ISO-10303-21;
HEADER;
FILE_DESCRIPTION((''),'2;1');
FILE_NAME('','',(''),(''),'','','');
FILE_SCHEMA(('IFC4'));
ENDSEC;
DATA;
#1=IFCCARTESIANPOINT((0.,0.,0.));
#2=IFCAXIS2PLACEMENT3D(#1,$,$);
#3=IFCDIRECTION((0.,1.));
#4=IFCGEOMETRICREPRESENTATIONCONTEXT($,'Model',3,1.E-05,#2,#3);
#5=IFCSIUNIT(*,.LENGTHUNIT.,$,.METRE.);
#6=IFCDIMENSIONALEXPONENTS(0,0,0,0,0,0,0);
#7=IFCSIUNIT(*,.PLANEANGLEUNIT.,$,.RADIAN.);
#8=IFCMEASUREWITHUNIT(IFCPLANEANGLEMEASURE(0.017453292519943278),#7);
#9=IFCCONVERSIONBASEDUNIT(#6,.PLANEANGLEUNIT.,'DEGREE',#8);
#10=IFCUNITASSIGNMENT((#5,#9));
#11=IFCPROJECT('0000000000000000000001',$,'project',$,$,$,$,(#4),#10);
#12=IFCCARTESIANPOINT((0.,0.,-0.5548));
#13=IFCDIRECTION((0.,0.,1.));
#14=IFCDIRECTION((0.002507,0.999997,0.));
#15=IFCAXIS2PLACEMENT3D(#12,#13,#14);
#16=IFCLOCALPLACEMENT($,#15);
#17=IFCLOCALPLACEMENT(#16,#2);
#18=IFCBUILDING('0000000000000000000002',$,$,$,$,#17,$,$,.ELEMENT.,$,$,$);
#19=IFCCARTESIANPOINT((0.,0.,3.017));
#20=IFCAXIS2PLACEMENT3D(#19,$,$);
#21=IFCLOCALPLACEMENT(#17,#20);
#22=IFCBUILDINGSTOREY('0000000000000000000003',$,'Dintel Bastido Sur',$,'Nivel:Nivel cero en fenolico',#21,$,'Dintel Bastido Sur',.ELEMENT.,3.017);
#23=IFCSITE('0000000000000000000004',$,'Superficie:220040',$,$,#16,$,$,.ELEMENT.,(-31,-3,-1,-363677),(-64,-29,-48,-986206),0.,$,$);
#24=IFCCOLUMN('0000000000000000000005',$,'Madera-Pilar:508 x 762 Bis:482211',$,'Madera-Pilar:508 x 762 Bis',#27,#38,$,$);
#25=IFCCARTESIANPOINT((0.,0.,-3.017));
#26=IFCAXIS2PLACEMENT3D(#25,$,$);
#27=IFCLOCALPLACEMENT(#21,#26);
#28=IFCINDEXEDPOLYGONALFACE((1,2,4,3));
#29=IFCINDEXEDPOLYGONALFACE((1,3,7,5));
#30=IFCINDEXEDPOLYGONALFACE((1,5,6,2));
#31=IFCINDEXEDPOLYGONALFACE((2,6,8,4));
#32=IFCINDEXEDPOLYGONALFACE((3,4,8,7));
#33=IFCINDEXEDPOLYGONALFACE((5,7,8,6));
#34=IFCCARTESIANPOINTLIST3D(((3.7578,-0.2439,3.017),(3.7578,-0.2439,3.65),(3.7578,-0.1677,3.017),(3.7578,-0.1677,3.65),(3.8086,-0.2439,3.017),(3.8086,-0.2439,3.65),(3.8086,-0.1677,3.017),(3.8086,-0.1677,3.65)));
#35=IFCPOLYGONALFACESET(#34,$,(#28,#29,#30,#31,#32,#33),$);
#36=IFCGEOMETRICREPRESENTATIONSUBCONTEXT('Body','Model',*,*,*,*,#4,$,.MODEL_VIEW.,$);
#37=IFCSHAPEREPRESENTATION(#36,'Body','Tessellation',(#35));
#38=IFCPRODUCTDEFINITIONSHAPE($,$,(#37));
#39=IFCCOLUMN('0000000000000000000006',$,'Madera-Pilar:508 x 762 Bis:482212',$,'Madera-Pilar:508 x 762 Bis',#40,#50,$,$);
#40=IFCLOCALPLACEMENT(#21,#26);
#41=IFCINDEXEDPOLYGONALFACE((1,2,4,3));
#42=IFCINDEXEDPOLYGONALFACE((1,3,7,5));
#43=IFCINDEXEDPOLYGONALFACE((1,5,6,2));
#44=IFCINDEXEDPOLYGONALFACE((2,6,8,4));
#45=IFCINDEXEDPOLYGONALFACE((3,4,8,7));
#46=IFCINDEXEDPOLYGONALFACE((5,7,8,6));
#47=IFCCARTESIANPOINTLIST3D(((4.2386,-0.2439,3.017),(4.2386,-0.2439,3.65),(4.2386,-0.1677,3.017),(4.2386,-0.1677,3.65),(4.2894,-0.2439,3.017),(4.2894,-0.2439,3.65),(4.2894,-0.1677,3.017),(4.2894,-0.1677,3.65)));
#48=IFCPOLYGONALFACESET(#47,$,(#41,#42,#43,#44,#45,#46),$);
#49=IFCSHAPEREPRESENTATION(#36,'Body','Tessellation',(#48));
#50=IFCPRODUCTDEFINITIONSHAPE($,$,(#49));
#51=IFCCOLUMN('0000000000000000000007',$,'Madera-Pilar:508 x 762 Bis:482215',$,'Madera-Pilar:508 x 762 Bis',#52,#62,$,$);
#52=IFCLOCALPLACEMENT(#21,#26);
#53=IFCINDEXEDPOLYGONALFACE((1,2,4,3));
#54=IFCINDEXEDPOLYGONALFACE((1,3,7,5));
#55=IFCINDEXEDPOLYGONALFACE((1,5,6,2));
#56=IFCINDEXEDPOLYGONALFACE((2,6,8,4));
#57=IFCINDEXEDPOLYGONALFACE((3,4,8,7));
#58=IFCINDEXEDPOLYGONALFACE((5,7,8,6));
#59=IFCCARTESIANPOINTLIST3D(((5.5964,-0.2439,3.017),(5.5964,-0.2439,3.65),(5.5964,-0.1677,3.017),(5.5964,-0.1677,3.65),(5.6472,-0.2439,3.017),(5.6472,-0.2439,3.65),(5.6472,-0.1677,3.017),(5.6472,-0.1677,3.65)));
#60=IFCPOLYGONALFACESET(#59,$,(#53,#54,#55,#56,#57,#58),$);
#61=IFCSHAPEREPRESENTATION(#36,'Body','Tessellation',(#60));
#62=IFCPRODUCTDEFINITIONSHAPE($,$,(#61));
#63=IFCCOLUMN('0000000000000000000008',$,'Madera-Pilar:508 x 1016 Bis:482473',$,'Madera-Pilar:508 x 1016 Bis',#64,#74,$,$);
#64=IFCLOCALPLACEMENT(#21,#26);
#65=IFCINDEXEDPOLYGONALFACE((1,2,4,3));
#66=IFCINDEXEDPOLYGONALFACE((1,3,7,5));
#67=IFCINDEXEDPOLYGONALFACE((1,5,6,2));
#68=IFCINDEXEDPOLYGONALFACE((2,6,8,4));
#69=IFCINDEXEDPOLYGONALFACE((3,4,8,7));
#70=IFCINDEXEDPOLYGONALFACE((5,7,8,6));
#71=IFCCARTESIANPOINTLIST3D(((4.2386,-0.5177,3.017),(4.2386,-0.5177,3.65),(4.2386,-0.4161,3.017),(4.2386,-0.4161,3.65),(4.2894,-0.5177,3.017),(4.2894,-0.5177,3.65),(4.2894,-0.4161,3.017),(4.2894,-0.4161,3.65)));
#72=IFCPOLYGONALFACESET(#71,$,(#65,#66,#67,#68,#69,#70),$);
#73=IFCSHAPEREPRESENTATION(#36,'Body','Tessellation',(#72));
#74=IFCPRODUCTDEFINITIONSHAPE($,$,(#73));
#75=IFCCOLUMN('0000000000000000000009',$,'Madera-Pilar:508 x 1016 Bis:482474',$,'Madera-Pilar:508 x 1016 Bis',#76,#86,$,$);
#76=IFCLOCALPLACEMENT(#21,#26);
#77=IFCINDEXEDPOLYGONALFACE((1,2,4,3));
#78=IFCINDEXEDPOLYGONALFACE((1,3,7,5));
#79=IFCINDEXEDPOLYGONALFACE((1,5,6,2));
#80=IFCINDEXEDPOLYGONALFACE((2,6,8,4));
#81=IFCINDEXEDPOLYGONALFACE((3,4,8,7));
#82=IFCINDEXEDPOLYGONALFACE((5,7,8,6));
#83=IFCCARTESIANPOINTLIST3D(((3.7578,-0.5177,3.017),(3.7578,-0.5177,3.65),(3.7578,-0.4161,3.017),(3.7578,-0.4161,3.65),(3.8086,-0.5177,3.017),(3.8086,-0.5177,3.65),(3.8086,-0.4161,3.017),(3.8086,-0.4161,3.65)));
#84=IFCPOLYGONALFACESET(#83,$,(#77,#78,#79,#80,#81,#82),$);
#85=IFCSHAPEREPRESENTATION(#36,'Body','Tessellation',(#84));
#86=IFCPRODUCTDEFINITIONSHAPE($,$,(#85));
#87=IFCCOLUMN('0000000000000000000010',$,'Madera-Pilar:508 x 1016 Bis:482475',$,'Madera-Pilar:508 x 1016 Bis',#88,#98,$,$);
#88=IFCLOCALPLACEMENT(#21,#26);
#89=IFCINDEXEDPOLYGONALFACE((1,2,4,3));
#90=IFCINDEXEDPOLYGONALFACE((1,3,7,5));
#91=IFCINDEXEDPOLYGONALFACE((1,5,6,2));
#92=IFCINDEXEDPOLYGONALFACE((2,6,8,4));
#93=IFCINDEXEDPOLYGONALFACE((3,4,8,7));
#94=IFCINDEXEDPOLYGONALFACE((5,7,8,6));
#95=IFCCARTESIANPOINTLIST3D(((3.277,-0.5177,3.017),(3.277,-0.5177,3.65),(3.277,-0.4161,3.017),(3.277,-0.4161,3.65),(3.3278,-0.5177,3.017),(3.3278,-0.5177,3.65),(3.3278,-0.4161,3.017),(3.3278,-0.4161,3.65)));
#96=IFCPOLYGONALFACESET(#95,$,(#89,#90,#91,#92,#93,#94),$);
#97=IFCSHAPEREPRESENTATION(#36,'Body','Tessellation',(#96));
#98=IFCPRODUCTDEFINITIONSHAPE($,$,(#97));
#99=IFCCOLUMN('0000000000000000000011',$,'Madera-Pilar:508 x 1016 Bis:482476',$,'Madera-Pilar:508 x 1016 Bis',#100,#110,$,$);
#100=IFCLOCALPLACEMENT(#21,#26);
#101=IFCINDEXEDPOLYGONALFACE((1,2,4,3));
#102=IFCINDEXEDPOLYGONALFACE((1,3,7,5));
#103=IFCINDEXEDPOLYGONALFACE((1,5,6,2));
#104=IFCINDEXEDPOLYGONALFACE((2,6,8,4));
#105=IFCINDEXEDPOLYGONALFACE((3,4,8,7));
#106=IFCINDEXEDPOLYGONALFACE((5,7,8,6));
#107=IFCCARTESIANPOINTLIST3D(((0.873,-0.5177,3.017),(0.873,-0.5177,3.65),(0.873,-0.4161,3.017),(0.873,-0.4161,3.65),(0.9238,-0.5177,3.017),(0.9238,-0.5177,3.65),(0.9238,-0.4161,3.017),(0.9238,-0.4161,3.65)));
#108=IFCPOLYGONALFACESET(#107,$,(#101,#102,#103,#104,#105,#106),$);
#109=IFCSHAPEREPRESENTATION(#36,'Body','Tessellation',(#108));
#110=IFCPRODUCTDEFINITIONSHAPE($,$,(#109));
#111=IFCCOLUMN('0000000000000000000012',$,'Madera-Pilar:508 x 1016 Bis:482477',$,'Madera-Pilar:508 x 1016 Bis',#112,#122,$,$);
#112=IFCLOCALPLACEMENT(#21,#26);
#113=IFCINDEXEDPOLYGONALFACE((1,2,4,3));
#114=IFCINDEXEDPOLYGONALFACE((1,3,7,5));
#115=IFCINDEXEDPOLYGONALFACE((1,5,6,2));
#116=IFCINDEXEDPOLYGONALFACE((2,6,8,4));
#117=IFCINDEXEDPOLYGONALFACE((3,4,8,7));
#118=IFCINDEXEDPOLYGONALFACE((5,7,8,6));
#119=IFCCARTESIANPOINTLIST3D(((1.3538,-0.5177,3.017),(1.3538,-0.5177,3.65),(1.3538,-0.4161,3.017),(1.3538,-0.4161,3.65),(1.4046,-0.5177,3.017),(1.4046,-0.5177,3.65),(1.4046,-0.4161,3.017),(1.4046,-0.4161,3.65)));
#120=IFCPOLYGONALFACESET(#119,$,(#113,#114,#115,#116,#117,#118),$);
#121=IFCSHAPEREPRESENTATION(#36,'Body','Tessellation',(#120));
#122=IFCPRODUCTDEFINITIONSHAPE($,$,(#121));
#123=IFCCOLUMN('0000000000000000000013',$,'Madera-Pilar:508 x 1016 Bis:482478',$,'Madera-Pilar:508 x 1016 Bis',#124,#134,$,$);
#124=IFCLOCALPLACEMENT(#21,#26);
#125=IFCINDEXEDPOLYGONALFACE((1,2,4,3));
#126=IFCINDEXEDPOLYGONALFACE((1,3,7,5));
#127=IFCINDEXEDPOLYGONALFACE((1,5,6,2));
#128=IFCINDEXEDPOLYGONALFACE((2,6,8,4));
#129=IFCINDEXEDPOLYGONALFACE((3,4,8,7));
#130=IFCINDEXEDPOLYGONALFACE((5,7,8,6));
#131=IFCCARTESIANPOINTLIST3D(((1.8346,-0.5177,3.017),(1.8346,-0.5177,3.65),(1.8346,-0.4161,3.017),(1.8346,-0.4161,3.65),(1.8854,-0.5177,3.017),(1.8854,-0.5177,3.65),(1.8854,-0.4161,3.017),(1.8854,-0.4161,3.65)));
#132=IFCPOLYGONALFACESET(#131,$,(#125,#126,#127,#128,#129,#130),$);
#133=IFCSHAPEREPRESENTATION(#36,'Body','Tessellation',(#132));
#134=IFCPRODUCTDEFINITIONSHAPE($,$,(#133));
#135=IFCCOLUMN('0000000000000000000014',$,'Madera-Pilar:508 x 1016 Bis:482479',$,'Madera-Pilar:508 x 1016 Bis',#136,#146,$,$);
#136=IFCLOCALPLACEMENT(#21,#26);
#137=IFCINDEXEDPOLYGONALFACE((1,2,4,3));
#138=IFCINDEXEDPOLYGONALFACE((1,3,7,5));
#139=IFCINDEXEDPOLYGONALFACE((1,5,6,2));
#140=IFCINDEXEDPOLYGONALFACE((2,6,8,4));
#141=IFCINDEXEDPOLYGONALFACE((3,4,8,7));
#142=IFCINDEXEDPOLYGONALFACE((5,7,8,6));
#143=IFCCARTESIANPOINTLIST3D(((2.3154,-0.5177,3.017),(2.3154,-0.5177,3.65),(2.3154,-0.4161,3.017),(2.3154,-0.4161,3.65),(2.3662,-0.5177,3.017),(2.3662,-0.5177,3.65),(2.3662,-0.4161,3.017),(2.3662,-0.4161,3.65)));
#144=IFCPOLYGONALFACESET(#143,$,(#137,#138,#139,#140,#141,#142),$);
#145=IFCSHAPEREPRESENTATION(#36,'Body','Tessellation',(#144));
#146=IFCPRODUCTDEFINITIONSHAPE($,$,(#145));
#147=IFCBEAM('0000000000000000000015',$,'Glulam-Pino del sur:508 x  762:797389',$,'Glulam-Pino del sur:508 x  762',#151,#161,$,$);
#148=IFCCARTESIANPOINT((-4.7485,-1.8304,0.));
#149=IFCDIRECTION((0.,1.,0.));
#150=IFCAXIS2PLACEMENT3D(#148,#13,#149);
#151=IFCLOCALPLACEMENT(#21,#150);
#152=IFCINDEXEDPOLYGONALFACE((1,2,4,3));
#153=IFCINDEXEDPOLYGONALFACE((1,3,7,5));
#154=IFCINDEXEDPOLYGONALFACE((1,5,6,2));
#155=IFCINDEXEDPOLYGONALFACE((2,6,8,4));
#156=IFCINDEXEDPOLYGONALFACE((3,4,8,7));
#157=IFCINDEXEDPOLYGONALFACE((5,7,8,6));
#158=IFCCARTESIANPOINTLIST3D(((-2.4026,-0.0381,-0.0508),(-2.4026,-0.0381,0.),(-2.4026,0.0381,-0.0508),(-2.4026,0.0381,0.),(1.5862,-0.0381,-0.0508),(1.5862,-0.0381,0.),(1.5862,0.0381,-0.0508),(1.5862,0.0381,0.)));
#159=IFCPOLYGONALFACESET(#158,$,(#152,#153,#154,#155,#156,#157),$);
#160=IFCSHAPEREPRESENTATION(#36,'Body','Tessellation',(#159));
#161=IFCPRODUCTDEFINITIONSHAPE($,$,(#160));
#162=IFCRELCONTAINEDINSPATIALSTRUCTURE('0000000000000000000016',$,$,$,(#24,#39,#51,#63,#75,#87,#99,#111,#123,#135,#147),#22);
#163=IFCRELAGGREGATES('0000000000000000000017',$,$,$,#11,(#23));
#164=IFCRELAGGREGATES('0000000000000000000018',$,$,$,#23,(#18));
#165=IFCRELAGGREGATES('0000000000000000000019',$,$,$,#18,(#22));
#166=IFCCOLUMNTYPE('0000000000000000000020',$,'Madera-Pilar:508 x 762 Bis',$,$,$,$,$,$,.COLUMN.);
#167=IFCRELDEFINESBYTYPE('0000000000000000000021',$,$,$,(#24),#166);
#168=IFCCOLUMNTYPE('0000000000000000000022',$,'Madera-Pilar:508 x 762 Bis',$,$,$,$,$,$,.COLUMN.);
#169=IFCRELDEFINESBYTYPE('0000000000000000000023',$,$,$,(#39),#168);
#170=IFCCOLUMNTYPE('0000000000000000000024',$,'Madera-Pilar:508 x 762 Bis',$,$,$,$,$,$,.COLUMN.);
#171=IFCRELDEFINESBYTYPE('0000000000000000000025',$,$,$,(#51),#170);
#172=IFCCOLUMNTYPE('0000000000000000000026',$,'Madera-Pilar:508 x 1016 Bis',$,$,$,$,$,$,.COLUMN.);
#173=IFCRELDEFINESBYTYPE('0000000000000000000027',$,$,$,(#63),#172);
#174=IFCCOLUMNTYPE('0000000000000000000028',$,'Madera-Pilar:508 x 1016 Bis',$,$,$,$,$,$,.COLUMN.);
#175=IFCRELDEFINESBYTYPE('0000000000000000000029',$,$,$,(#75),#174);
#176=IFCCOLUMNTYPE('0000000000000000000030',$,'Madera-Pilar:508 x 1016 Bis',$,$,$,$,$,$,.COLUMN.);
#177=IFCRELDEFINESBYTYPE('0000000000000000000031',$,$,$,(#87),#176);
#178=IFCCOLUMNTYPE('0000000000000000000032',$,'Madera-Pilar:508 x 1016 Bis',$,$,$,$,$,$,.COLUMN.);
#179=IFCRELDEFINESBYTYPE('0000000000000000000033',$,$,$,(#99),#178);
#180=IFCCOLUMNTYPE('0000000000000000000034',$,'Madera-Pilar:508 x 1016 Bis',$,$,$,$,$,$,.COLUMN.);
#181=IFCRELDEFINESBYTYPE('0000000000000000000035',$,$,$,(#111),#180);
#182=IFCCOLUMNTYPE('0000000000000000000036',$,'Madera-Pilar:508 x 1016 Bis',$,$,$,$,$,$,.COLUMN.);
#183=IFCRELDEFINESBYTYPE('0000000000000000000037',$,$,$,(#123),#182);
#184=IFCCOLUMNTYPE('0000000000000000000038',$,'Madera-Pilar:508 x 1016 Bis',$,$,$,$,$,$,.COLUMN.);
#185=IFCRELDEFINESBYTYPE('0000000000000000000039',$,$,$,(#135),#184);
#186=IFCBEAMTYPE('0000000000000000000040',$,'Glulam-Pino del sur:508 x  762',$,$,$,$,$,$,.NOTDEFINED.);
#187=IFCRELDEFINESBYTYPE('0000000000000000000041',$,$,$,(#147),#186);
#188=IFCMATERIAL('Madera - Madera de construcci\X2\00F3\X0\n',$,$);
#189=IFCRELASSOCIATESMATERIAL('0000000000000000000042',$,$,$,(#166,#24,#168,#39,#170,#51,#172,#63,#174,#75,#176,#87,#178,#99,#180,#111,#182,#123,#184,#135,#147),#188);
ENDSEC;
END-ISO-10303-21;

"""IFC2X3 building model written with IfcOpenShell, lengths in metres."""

from ifc_helpers import new_model, entity, si_unit, converted_unit, direction, frame, frame_2d, origin, place, context, subcontext, project, spatial, rectangle, extrude, source, transform, mapped, material, type_object, type_shapes, element, save


model = new_model("IFC2X3")

# Units and contexts
model_context = context("Model", 3, precision=1e-05, world=origin(), true_north=direction((0.0, 1.0)))
body_context = subcontext(model_context, "Body", "Model", "MODEL_VIEW")
ifc_project = project(units=[si_unit("LENGTHUNIT", "METRE"), converted_unit("PLANEANGLEUNIT", "DEGREE", entity("IfcPlaneAngleMeasure", 0.017453292519943278), si_unit("PLANEANGLEUNIT", "RADIAN"), dimensions=[0, 0, 0, 0, 0, 0, 0])], contexts=[model_context])

# Site, building, storey
site_placement = place(None, frame((0.0, 0.0, -0.5548), z_axis=(0.0, 0.0, 1.0), x_axis=(0.002507, 0.999997, 0.0)))
site = spatial("IfcSite", under=ifc_project, at=site_placement, Name="Superficie:220040", CompositionType="ELEMENT", RefLatitude=(-31, -3, -1, -363677), RefLongitude=(-64, -29, -48, -986206), RefElevation=0.0)
building_placement = place(site_placement, origin())
building = spatial("IfcBuilding", under=site, at=building_placement, CompositionType="ELEMENT")
storey_placement = place(building_placement, frame((0.0, 0.0, 3.017)))
storey = spatial("IfcBuildingStorey", under=building, at=storey_placement, Name="Dintel Bastido Sur", ObjectType="Nivel:Nivel cero en fenolico", LongName="Dintel Bastido Sur", CompositionType="ELEMENT", Elevation=3.017)

# Columns
ifc_material_1 = material(Name="Madera - Madera de construcción")
column_type_1 = type_object("IfcColumnType", Name="Madera-Pilar:508 x 762 Bis", PredefinedType="COLUMN", material=ifc_material_1)
shared_shape_1 = source(origin(), body_context, "Body", "SweptSolid", [
    extrude(rectangle(XDim=0.0508, YDim=0.0762, at=frame_2d((0.0, 0.0), x_axis=(1.0, 0.0))), frame((3.7832, -0.2058, 3.017), z_axis=(0.0, 0.0, 1.0), x_axis=(-1.0, 0.0, 0.0)), (0.0, 0.0, 1.0), 0.633),
])
type_shapes(column_type_1, [shared_shape_1])
column_1_placement = place(storey_placement, frame((0.0, 0.0, -3.017)))
element("IfcColumn", 1, at=column_1_placement, inside=storey, type_object=column_type_1, material=ifc_material_1, Name="Madera-Pilar:508 x 762 Bis:482211", ObjectType="Madera-Pilar:508 x 762 Bis", context=body_context, shape_type="MappedRepresentation", body=[
    mapped(shared_shape_1, transform((0.0, 0.0, 0.0), scale=1.0)),
])
column_type_2 = type_object("IfcColumnType", Name="Madera-Pilar:508 x 762 Bis", PredefinedType="COLUMN", material=ifc_material_1)
shared_shape_2 = source(origin(), body_context, "Body", "SweptSolid", [
    extrude(rectangle(XDim=0.0508, YDim=0.0762, at=frame_2d((0.0, 0.0), x_axis=(1.0, 0.0))), frame((4.264, -0.2058, 3.017), z_axis=(0.0, 0.0, 1.0), x_axis=(-1.0, 0.0, 0.0)), (0.0, 0.0, 1.0), 0.633),
])
type_shapes(column_type_2, [shared_shape_2])
column_2_placement = place(storey_placement, frame((0.0, 0.0, -3.017)))
element("IfcColumn", 2, at=column_2_placement, inside=storey, type_object=column_type_2, material=ifc_material_1, Name="Madera-Pilar:508 x 762 Bis:482212", ObjectType="Madera-Pilar:508 x 762 Bis", context=body_context, shape_type="MappedRepresentation", body=[
    mapped(shared_shape_2, transform((0.0, 0.0, 0.0), scale=1.0)),
])
column_type_3 = type_object("IfcColumnType", Name="Madera-Pilar:508 x 762 Bis", PredefinedType="COLUMN", material=ifc_material_1)
shared_shape_3 = source(origin(), body_context, "Body", "SweptSolid", [
    extrude(rectangle(XDim=0.0508, YDim=0.0762, at=frame_2d((0.0, 0.0), x_axis=(1.0, 0.0))), frame((5.6218, -0.2058, 3.017), z_axis=(0.0, 0.0, 1.0), x_axis=(-1.0, 0.0, 0.0)), (0.0, 0.0, 1.0), 0.633),
])
type_shapes(column_type_3, [shared_shape_3])
column_3_placement = place(storey_placement, frame((0.0, 0.0, -3.017)))
element("IfcColumn", 3, at=column_3_placement, inside=storey, type_object=column_type_3, material=ifc_material_1, Name="Madera-Pilar:508 x 762 Bis:482215", ObjectType="Madera-Pilar:508 x 762 Bis", context=body_context, shape_type="MappedRepresentation", body=[
    mapped(shared_shape_3, transform((0.0, 0.0, 0.0), scale=1.0)),
])
column_type_4 = type_object("IfcColumnType", Name="Madera-Pilar:508 x 1016 Bis", PredefinedType="COLUMN", material=ifc_material_1)
shared_shape_4 = source(origin(), body_context, "Body", "SweptSolid", [
    extrude(rectangle(XDim=0.0508, YDim=0.1016, at=frame_2d((0.0, 0.0), x_axis=(1.0, 0.0))), frame((4.264, -0.4669, 3.017)), (0.0, 0.0, 1.0), 0.633),
])
type_shapes(column_type_4, [shared_shape_4])
column_4_placement = place(storey_placement, frame((0.0, 0.0, -3.017)))
element("IfcColumn", 4, at=column_4_placement, inside=storey, type_object=column_type_4, material=ifc_material_1, Name="Madera-Pilar:508 x 1016 Bis:482473", ObjectType="Madera-Pilar:508 x 1016 Bis", context=body_context, shape_type="MappedRepresentation", body=[
    mapped(shared_shape_4, transform((0.0, 0.0, 0.0), scale=1.0)),
])
column_type_5 = type_object("IfcColumnType", Name="Madera-Pilar:508 x 1016 Bis", PredefinedType="COLUMN", material=ifc_material_1)
shared_shape_5 = source(origin(), body_context, "Body", "SweptSolid", [
    extrude(rectangle(XDim=0.0508, YDim=0.1016, at=frame_2d((0.0, 0.0), x_axis=(1.0, 0.0))), frame((3.7832, -0.4669, 3.017)), (0.0, 0.0, 1.0), 0.633),
])
type_shapes(column_type_5, [shared_shape_5])
column_5_placement = place(storey_placement, frame((0.0, 0.0, -3.017)))
element("IfcColumn", 5, at=column_5_placement, inside=storey, type_object=column_type_5, material=ifc_material_1, Name="Madera-Pilar:508 x 1016 Bis:482474", ObjectType="Madera-Pilar:508 x 1016 Bis", context=body_context, shape_type="MappedRepresentation", body=[
    mapped(shared_shape_5, transform((0.0, 0.0, 0.0), scale=1.0)),
])
column_type_6 = type_object("IfcColumnType", Name="Madera-Pilar:508 x 1016 Bis", PredefinedType="COLUMN", material=ifc_material_1)
shared_shape_6 = source(origin(), body_context, "Body", "SweptSolid", [
    extrude(rectangle(XDim=0.0508, YDim=0.1016, at=frame_2d((0.0, 0.0), x_axis=(1.0, 0.0))), frame((3.3024, -0.4669, 3.017)), (0.0, 0.0, 1.0), 0.633),
])
type_shapes(column_type_6, [shared_shape_6])
column_6_placement = place(storey_placement, frame((0.0, 0.0, -3.017)))
element("IfcColumn", 6, at=column_6_placement, inside=storey, type_object=column_type_6, material=ifc_material_1, Name="Madera-Pilar:508 x 1016 Bis:482475", ObjectType="Madera-Pilar:508 x 1016 Bis", context=body_context, shape_type="MappedRepresentation", body=[
    mapped(shared_shape_6, transform((0.0, 0.0, 0.0), scale=1.0)),
])
column_type_7 = type_object("IfcColumnType", Name="Madera-Pilar:508 x 1016 Bis", PredefinedType="COLUMN", material=ifc_material_1)
shared_shape_7 = source(origin(), body_context, "Body", "SweptSolid", [
    extrude(rectangle(XDim=0.0508, YDim=0.1016, at=frame_2d((0.0, 0.0), x_axis=(1.0, 0.0))), frame((0.8984, -0.4669, 3.017)), (0.0, 0.0, 1.0), 0.633),
])
type_shapes(column_type_7, [shared_shape_7])
column_7_placement = place(storey_placement, frame((0.0, 0.0, -3.017)))
element("IfcColumn", 7, at=column_7_placement, inside=storey, type_object=column_type_7, material=ifc_material_1, Name="Madera-Pilar:508 x 1016 Bis:482476", ObjectType="Madera-Pilar:508 x 1016 Bis", context=body_context, shape_type="MappedRepresentation", body=[
    mapped(shared_shape_7, transform((0.0, 0.0, 0.0), scale=1.0)),
])
column_type_8 = type_object("IfcColumnType", Name="Madera-Pilar:508 x 1016 Bis", PredefinedType="COLUMN", material=ifc_material_1)
shared_shape_8 = source(origin(), body_context, "Body", "SweptSolid", [
    extrude(rectangle(XDim=0.0508, YDim=0.1016, at=frame_2d((0.0, 0.0), x_axis=(1.0, 0.0))), frame((1.3792, -0.4669, 3.017)), (0.0, 0.0, 1.0), 0.633),
])
type_shapes(column_type_8, [shared_shape_8])
column_8_placement = place(storey_placement, frame((0.0, 0.0, -3.017)))
element("IfcColumn", 8, at=column_8_placement, inside=storey, type_object=column_type_8, material=ifc_material_1, Name="Madera-Pilar:508 x 1016 Bis:482477", ObjectType="Madera-Pilar:508 x 1016 Bis", context=body_context, shape_type="MappedRepresentation", body=[
    mapped(shared_shape_8, transform((0.0, 0.0, 0.0), scale=1.0)),
])
column_type_9 = type_object("IfcColumnType", Name="Madera-Pilar:508 x 1016 Bis", PredefinedType="COLUMN", material=ifc_material_1)
shared_shape_9 = source(origin(), body_context, "Body", "SweptSolid", [
    extrude(rectangle(XDim=0.0508, YDim=0.1016, at=frame_2d((0.0, 0.0), x_axis=(1.0, 0.0))), frame((1.86, -0.4669, 3.017)), (0.0, 0.0, 1.0), 0.633),
])
type_shapes(column_type_9, [shared_shape_9])
column_9_placement = place(storey_placement, frame((0.0, 0.0, -3.017)))
element("IfcColumn", 9, at=column_9_placement, inside=storey, type_object=column_type_9, material=ifc_material_1, Name="Madera-Pilar:508 x 1016 Bis:482478", ObjectType="Madera-Pilar:508 x 1016 Bis", context=body_context, shape_type="MappedRepresentation", body=[
    mapped(shared_shape_9, transform((0.0, 0.0, 0.0), scale=1.0)),
])
column_type_10 = type_object("IfcColumnType", Name="Madera-Pilar:508 x 1016 Bis", PredefinedType="COLUMN", material=ifc_material_1)
shared_shape_10 = source(origin(), body_context, "Body", "SweptSolid", [
    extrude(rectangle(XDim=0.0508, YDim=0.1016, at=frame_2d((0.0, 0.0), x_axis=(1.0, 0.0))), frame((2.3408, -0.4669, 3.017)), (0.0, 0.0, 1.0), 0.633),
])
type_shapes(column_type_10, [shared_shape_10])
column_10_placement = place(storey_placement, frame((0.0, 0.0, -3.017)))
element("IfcColumn", 10, at=column_10_placement, inside=storey, type_object=column_type_10, material=ifc_material_1, Name="Madera-Pilar:508 x 1016 Bis:482479", ObjectType="Madera-Pilar:508 x 1016 Bis", context=body_context, shape_type="MappedRepresentation", body=[
    mapped(shared_shape_10, transform((0.0, 0.0, 0.0), scale=1.0)),
])

# Beam
beam_type_1 = type_object("IfcBeamType", Name="Glulam-Pino del sur:508 x  762", PredefinedType="NOTDEFINED")
beam_1_placement = place(storey_placement, frame((-4.7485, -1.8304, 0.0), z_axis=(0.0, 0.0, 1.0), x_axis=(0.0, 1.0, 0.0)))
element("IfcBeam", 11, at=beam_1_placement, inside=storey, type_object=beam_type_1, material=ifc_material_1, Name="Glulam-Pino del sur:508 x  762:797389", ObjectType="Glulam-Pino del sur:508 x  762", context=body_context, shape_type="SweptSolid", body=[
    extrude(rectangle(XDim=0.0508, YDim=0.0762, at=frame_2d((0.0, 0.0), x_axis=(1.0, 0.0))), frame((-2.4026, 0.0, -0.0254), z_axis=(1.0, 0.0, 0.0), x_axis=(0.0, 0.0, -1.0)), (0.0, 0.0, 1.0), 3.9888),
])

save(model, "model.ifc")
